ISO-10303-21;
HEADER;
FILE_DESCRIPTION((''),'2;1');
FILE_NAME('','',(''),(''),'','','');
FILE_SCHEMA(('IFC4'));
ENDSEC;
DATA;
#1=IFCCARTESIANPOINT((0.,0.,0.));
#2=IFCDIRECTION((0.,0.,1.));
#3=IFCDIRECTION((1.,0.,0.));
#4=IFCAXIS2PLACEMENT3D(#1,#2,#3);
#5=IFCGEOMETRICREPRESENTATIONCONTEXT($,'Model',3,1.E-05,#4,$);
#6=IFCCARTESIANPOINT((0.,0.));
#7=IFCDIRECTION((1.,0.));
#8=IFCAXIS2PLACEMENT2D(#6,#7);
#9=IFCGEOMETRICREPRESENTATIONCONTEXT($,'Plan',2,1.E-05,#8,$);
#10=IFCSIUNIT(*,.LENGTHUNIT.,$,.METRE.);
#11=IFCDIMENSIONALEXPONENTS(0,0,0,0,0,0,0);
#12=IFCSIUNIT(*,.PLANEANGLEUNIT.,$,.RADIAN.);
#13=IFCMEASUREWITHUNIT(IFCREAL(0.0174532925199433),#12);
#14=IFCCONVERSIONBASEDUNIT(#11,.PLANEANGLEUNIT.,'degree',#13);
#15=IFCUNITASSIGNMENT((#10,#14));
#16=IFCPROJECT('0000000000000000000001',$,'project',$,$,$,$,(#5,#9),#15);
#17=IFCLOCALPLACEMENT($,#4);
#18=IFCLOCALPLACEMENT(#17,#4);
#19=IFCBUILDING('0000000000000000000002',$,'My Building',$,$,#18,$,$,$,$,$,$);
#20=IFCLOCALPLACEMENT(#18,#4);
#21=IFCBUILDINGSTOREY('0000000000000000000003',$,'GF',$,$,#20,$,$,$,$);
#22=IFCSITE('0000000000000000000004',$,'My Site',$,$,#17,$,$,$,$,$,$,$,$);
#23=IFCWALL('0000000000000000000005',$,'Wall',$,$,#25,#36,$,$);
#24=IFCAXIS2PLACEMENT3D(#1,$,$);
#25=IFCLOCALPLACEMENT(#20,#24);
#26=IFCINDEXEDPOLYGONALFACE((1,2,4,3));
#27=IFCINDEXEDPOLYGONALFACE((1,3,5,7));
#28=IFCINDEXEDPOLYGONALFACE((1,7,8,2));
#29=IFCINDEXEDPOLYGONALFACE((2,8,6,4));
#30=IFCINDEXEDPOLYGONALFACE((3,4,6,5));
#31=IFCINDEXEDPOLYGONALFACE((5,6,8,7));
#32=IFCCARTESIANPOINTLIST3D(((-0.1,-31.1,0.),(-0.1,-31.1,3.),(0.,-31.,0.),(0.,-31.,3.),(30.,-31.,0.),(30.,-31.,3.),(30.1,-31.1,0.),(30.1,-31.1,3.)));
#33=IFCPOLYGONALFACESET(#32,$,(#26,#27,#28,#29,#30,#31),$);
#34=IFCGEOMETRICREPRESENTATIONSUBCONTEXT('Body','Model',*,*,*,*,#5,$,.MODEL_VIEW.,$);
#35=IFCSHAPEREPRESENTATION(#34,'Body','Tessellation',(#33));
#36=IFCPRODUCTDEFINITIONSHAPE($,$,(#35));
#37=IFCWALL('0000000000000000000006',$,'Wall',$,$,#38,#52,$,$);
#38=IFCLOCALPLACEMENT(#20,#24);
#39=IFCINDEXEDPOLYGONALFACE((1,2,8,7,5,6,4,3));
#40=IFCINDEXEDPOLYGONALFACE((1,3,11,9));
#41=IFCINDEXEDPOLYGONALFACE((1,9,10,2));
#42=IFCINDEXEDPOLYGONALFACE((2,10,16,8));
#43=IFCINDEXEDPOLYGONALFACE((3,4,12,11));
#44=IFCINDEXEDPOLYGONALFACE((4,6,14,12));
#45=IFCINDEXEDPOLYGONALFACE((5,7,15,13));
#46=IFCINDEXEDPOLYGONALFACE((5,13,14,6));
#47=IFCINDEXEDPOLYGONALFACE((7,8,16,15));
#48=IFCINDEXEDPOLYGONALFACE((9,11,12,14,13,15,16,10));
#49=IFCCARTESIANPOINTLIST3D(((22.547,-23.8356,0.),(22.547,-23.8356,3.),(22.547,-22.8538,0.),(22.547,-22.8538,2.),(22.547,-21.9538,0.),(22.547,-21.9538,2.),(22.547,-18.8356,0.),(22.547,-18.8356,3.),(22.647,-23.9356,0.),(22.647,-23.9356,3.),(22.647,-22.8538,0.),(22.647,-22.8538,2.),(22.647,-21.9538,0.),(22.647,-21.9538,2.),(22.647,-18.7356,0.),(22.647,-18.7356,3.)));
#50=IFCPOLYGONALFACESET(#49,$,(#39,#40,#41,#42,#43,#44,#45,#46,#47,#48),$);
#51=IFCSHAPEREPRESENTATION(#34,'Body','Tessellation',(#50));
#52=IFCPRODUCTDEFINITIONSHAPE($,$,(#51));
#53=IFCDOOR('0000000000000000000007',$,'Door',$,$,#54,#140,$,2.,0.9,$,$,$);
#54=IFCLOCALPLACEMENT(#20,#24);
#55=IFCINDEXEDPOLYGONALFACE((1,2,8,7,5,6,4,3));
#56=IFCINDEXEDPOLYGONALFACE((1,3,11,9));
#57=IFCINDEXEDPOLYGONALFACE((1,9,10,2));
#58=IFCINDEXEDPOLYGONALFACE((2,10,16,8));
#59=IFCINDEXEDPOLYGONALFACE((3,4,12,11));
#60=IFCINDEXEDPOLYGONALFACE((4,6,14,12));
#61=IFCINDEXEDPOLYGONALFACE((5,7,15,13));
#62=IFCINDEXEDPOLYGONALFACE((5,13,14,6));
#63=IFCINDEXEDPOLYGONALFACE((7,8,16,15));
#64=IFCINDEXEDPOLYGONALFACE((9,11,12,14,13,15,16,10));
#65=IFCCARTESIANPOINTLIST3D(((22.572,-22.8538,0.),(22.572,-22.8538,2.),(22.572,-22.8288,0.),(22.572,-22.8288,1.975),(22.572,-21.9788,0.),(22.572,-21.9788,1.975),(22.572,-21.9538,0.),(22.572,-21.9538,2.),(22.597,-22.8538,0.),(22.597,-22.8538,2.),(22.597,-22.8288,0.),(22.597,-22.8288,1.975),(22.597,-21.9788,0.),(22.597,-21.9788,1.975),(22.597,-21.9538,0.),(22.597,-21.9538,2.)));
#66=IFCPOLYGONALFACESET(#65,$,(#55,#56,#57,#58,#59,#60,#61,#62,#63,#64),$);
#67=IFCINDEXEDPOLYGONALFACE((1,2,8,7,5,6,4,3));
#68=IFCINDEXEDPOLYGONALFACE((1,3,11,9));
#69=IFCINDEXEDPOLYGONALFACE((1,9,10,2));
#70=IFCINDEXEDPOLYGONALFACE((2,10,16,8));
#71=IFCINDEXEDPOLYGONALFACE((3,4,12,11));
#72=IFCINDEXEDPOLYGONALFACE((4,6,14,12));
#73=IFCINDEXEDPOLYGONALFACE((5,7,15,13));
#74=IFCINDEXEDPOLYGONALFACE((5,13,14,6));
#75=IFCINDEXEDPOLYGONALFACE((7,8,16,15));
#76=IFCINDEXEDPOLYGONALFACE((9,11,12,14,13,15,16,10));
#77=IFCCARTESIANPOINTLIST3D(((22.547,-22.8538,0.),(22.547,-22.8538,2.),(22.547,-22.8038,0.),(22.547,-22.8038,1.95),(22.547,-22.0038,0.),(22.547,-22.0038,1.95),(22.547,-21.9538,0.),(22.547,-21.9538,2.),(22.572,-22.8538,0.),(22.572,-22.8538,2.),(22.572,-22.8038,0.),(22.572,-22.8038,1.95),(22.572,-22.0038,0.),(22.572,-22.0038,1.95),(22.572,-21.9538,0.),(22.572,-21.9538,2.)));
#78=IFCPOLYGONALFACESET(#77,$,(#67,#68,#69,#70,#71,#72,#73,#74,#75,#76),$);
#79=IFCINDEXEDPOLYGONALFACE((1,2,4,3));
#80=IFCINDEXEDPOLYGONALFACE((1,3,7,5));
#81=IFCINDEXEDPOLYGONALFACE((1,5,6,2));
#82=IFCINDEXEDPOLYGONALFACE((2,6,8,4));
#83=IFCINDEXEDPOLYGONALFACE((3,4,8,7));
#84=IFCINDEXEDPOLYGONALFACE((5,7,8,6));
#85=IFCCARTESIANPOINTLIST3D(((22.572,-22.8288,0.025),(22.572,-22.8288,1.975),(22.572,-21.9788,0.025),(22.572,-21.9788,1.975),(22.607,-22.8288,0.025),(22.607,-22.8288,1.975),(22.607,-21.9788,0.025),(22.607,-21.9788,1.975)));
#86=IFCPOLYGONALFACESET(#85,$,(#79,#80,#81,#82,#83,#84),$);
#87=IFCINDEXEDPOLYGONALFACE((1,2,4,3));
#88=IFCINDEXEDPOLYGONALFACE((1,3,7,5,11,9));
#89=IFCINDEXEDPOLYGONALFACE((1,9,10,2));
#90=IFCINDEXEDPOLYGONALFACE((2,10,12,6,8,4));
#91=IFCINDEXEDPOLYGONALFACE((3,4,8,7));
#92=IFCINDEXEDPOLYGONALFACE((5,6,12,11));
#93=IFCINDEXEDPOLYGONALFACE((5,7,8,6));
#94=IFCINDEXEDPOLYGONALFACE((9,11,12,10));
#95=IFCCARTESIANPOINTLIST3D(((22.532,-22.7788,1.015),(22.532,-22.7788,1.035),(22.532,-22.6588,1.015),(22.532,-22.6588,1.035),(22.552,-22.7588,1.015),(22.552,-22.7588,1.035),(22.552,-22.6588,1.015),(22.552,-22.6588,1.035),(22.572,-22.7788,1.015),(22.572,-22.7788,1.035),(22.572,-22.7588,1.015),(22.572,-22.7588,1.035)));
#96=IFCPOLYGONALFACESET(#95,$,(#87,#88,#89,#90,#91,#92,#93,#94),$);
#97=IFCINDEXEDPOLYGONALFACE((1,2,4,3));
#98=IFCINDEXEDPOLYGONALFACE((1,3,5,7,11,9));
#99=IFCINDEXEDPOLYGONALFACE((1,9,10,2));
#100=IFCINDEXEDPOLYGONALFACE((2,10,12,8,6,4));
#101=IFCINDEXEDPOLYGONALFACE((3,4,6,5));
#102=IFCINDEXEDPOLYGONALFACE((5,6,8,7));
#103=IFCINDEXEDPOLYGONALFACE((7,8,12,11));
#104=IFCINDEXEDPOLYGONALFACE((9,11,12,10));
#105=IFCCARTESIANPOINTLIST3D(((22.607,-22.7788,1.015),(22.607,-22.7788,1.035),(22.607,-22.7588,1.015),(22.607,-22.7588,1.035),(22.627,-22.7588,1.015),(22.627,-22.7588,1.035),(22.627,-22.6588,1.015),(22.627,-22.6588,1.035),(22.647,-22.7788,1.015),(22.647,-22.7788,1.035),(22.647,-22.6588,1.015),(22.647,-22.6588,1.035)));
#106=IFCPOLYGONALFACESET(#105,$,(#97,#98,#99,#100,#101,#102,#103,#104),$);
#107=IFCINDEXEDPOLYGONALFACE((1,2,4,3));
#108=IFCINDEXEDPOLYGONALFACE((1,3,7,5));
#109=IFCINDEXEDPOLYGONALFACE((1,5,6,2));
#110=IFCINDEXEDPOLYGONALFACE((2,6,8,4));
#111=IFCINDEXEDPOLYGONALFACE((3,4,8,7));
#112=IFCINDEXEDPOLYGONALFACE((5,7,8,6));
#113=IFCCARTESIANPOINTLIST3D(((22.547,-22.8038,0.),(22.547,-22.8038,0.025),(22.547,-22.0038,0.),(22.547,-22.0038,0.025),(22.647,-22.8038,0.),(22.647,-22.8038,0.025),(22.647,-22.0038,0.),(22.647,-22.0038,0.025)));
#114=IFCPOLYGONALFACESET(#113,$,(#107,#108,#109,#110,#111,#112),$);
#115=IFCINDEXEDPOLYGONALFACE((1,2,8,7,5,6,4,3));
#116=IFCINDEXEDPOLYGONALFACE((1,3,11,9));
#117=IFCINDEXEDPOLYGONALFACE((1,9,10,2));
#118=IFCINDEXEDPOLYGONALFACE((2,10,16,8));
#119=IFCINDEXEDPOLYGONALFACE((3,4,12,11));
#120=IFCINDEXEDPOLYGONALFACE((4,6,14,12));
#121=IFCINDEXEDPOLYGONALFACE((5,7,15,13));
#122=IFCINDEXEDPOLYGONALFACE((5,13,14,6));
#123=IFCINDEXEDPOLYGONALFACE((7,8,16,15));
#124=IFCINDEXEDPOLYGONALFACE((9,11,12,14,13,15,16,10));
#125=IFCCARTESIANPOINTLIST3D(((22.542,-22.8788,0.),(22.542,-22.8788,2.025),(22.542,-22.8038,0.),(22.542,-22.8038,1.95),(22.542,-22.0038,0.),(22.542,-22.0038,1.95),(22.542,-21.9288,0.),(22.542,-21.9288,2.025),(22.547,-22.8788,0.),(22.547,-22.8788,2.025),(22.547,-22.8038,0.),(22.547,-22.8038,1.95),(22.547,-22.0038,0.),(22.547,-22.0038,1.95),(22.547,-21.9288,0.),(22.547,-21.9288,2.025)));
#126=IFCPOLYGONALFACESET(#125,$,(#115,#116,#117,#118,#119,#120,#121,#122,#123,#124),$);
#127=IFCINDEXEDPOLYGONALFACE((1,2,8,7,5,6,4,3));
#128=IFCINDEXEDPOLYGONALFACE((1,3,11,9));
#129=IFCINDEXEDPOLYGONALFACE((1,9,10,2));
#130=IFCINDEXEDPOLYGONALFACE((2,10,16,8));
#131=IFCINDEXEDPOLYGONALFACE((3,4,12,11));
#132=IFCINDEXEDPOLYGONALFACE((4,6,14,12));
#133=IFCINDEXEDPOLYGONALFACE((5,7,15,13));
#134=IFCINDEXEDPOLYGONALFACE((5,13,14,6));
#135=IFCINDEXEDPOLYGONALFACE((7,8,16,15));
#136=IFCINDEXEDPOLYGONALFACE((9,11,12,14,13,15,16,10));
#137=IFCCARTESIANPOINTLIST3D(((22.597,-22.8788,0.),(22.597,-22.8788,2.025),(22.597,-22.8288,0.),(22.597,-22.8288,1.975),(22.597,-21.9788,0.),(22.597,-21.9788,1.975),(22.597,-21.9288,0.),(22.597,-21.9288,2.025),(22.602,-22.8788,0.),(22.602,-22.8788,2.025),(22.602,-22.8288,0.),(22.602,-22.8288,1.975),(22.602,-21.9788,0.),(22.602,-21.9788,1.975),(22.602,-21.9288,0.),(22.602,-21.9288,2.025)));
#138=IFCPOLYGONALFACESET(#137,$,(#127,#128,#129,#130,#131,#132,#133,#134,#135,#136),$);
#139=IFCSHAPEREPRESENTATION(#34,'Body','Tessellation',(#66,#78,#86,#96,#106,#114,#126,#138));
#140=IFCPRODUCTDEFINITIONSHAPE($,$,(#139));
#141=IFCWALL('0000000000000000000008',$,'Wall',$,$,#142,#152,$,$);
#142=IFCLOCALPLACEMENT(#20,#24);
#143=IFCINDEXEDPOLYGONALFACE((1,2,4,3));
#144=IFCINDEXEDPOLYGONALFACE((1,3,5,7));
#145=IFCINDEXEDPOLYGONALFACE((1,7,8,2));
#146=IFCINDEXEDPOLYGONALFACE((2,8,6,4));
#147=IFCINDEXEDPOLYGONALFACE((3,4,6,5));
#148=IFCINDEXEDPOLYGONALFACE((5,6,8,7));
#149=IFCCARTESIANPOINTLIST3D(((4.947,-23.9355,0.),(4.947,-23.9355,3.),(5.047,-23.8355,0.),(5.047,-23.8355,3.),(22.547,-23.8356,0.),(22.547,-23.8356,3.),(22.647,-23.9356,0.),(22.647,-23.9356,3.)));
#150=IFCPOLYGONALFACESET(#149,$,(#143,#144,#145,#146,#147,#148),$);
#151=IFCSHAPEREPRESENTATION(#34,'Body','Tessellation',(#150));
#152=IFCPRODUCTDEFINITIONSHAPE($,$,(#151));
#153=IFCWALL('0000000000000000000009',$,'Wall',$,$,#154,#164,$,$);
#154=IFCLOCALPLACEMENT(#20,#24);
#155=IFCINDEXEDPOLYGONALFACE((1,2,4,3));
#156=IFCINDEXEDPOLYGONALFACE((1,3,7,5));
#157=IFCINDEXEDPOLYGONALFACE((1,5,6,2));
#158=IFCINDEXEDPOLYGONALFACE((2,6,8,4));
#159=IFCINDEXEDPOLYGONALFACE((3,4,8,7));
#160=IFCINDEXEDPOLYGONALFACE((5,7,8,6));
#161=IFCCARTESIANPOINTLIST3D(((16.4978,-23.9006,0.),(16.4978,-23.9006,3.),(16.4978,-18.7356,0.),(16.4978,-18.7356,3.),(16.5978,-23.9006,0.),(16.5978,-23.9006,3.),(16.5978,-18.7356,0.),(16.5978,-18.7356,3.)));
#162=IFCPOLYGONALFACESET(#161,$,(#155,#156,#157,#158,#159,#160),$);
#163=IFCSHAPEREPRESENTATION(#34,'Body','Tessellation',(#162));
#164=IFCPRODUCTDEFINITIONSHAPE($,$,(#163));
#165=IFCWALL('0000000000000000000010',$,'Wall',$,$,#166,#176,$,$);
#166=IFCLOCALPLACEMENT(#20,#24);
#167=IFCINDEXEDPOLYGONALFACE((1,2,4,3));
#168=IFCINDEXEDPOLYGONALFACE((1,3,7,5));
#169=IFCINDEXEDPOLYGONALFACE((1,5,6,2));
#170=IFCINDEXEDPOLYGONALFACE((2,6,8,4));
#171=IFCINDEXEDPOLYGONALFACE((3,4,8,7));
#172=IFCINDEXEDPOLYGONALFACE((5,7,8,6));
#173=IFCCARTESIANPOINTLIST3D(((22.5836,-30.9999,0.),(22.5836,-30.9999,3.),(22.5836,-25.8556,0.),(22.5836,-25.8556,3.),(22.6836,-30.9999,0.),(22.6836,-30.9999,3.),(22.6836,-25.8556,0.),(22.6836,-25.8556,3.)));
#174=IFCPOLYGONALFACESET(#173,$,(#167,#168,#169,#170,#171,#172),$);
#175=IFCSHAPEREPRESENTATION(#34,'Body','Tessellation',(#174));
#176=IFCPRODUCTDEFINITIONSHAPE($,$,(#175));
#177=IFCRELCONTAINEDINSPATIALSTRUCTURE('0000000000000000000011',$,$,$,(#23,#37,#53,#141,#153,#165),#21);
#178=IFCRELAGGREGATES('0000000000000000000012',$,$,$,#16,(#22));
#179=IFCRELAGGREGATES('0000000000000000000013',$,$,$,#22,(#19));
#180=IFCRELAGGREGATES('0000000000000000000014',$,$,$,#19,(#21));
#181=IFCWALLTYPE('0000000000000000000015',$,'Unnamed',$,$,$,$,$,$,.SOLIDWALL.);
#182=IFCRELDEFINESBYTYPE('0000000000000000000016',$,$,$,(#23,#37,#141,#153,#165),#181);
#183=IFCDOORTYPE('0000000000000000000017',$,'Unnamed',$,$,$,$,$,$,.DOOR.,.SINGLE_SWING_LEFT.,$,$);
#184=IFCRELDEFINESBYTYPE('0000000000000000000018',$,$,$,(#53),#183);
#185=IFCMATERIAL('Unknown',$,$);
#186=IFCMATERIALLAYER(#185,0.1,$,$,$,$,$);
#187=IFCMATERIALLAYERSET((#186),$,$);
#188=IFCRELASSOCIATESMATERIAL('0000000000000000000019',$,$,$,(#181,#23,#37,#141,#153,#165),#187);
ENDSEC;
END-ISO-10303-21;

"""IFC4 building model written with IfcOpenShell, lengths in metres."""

from ifc_helpers import new_model, entity, si_unit, converted_unit, frame, origin_with_axes, origin_2d_with_axis, place, context, subcontext, project, spatial, line, indexed_curve, outline, extrude, shape, source, transform, mapped, material, layer, layer_set, layer_usage, type_object, type_shapes, element, fill, save


model = new_model("IFC4")

# Units and contexts
model_context = context("Model", 3, precision=1e-05, world=origin_with_axes())
plan_context = context("Plan", 2, precision=1e-05, world=origin_2d_with_axis())
body_context_1 = subcontext(model_context, "Body", "Model", "MODEL_VIEW")
body_context_2 = subcontext(plan_context, "Body", "Plan", "PLAN_VIEW")
ifc_project = project(units=[si_unit("LENGTHUNIT", "METRE"), converted_unit("PLANEANGLEUNIT", "degree", entity("IfcReal", 0.0174532925199433), si_unit("PLANEANGLEUNIT", "RADIAN"), dimensions=[0, 0, 0, 0, 0, 0, 0])], contexts=[model_context, plan_context])

# Site, building, storey
site_placement = place(None, origin_with_axes())
site = spatial("IfcSite", under=ifc_project, at=site_placement, Name="My Site")
building_placement = place(site_placement, origin_with_axes())
building = spatial("IfcBuilding", under=site, at=building_placement, Name="My Building")
storey_placement = place(building_placement, origin_with_axes())
storey = spatial("IfcBuildingStorey", under=building, at=storey_placement, Name="GF")

# Wall
ifc_material = material(Name="Unknown")
ifc_layer = layer(ifc_material, 0.1)
ifc_layer_set = layer_set([ifc_layer])
ifc_layer_usage_1 = layer_usage(ifc_layer_set, "AXIS2", "POSITIVE", 0.0)
wall_type = type_object("IfcWallType", Name="Unnamed", PredefinedType="SOLIDWALL", material=ifc_layer_set)
wall_1_placement = place(storey_placement, frame((30.0, -31.0, 0.0), z_axis=(0.0, 0.0, 1.0), x_axis=(-1.0, 0.0, 0.0)))
element("IfcWall", 1, at=wall_1_placement, inside=storey, type_object=wall_type, material=ifc_layer_usage_1, Name="Wall", context=body_context_1, shape_type="SweptSolid", body=[
    extrude(outline(indexed_curve([(0.0, 0.0), (-0.1, 0.1), (30.1, 0.1), (30.0, 0.0)], segments=[line(1, 2, 3, 4, 1)])), origin_with_axes(), (0.0, 0.0, 1.0), 3.0),
])

# Wall, opening, door
ifc_layer_usage_2 = layer_usage(ifc_layer_set, "AXIS2", "POSITIVE", 0.0)
wall_2_placement = place(storey_placement, frame((22.547, -18.8356, 0.0), z_axis=(0.0, 0.0, 1.0), x_axis=(0.0, -1.0, 0.0)))
wall_2 = element("IfcWall", 2, at=wall_2_placement, inside=storey, type_object=wall_type, material=ifc_layer_usage_2, Name="Wall", context=body_context_1, shape_type="SweptSolid", body=[
    extrude(outline(indexed_curve([(0.0, 0.0), (-0.1, 0.1), (5.1, 0.1), (5.0, 0.0)], segments=[line(1, 2, 3, 4, 1)])), origin_with_axes(), (0.0, 0.0, 1.0), 3.0),
])
shared_shape_1 = source(origin_with_axes(), body_context_1, "Body", "SweptSolid", [
    extrude(outline(indexed_curve([(0.0, 0.0), (0.9, 0.0), (0.9, 2.0), (0.0, 2.0)], segments=[line(1, 2, 3, 4, 1)])), frame((0.0, -0.6, 0.0), z_axis=(0.0, -1.0, 0.0), x_axis=(1.0, 0.0, 0.0)), (0.0, 0.0, -1.0), 1.2),
])
opening_placement = place(wall_2_placement, frame((3.1182, 0.0, 0.0), z_axis=(0.0, 0.0, 1.0), x_axis=(1.0, 0.0, 0.0)))
opening = element("IfcOpeningElement", 3, at=opening_placement, cuts=wall_2, PredefinedType="OPENING", context=body_context_1, shape_type="MappedRepresentation", body=[
    mapped(shared_shape_1, transform((0.0, 0.0, 0.0), x_axis=(1.0, 0.0, 0.0), y_axis=(0.0, 1.0, 0.0), z_axis=(0.0, 0.0, 1.0), scale=1.0)),
])
door_type = type_object("IfcDoorType", Name="Unnamed", OperationType="SINGLE_SWING_LEFT", PredefinedType="DOOR")
shared_shape_2 = source(origin_with_axes(), body_context_1, "Body", "SweptSolid", [
    extrude(outline(indexed_curve([(0.0, 0.0), (0.0, 2.0), (0.9, 2.0), (0.9, 0.0), (0.875, 0.0), (0.875, 1.975), (0.025, 1.975), (0.025, 0.0)], segments=[line(1, 2, 3, 4, 5, 6, 7, 8, 1)])), frame((0.0, 0.025, 0.0), z_axis=(0.0, -1.0, 0.0), x_axis=(1.0, 0.0, 0.0)), (0.0, 0.0, -1.0), 0.025),
    extrude(outline(indexed_curve([(0.0, 0.0), (0.0, 2.0), (0.9, 2.0), (0.9, 0.0), (0.85, 0.0), (0.85, 1.95), (0.05, 1.95), (0.05, 0.0)], segments=[line(1, 2, 3, 4, 5, 6, 7, 8, 1)])), frame((0.0, 0.0, 0.0), z_axis=(0.0, -1.0, 0.0), x_axis=(1.0, 0.0, 0.0)), (0.0, 0.0, -1.0), 0.025),
    extrude(outline(indexed_curve([(0.0, 0.0), (0.85, 0.0), (0.85, 0.035), (0.0, 0.035)], segments=[line(1, 2, 3, 4, 1)])), frame((0.025, 0.025, 0.025), z_axis=(0.0, 0.0, 1.0), x_axis=(1.0, 0.0, 0.0)), (0.0, 0.0, 1.0), 1.95),
    extrude(outline(indexed_curve([(0.0, 0.0), (0.0, -0.04), (-0.12, -0.04), (-0.12, -0.02), (-0.02, -0.02), (-0.02, 0.0)], segments=[line(1, 2, 3, 4, 5, 6, 1)])), frame((0.825, 0.025, 1.015), z_axis=(0.0, 0.0, 1.0), x_axis=(1.0, 0.0, 0.0)), (0.0, 0.0, 1.0), 0.02),
    extrude(outline(indexed_curve([(0.0, 0.0), (0.0, 0.04), (-0.12, 0.04), (-0.12, 0.02), (-0.02, 0.02), (-0.02, 0.0)], segments=[line(1, 2, 3, 4, 5, 6, 1)])), frame((0.825, 0.06, 1.015), z_axis=(0.0, 0.0, 1.0), x_axis=(1.0, 0.0, 0.0)), (0.0, 0.0, 1.0), 0.02),
    extrude(outline(indexed_curve([(0.0, 0.0), (0.8, 0.0), (0.8, 0.1), (0.0, 0.1)], segments=[line(1, 2, 3, 4, 1)])), frame((0.05, 0.0, 0.0), z_axis=(0.0, 0.0, 1.0), x_axis=(1.0, 0.0, 0.0)), (0.0, 0.0, 1.0), 0.025),
    extrude(outline(indexed_curve([(0.0, 0.0), (0.0, 2.025), (0.95, 2.025), (0.95, 0.0), (0.875, 0.0), (0.875, 1.95), (0.075, 1.95), (0.075, 0.0)], segments=[line(1, 2, 3, 4, 5, 6, 7, 8, 1)])), frame((-0.025, -0.005, 0.0), z_axis=(0.0, -1.0, 0.0), x_axis=(1.0, 0.0, 0.0)), (0.0, 0.0, -1.0), 0.005),
    extrude(outline(indexed_curve([(0.0, 0.0), (0.0, 2.025), (0.95, 2.025), (0.95, 0.0), (0.9, 0.0), (0.9, 1.975), (0.05, 1.975), (0.05, 0.0)], segments=[line(1, 2, 3, 4, 5, 6, 7, 8, 1)])), frame((-0.025, 0.05, 0.0), z_axis=(0.0, -1.0, 0.0), x_axis=(1.0, 0.0, 0.0)), (0.0, 0.0, -1.0), 0.005),
])
shared_shape_3 = source(origin_with_axes(), body_context_2, "Body", "Curve2D", [
    entity("IfcIndexedPolyCurve", entity("IfcCartesianPointList2D", [[0.0, 0.0], [0.0, 0.05], [0.025, 0.05], [0.025, 0.025], [0.05, 0.025], [0.05, 0.0]]), [entity("IfcLineIndex", [1, 2, 3, 4, 5, 6, 1])]),
    entity("IfcIndexedPolyCurve", entity("IfcCartesianPointList2D", [[0.9, 0.0], [0.9, 0.05], [0.875, 0.05], [0.875, 0.025], [0.85, 0.025], [0.85, 0.0]]), [entity("IfcLineIndex", [1, 2, 3, 4, 5, 6, 1])]),
    entity("IfcTrimmedCurve", entity("IfcEllipse", entity("IfcAxis2Placement2D", entity("IfcCartesianPoint", [0.06, 0.05]), entity("IfcDirection", [1.0, 0.0])), 0.815, 0.85), [entity("IfcCartesianPoint", [0.875, 0.05])], [entity("IfcCartesianPoint", [0.06, 0.9])], True, "CARTESIAN"),
    entity("IfcIndexedPolyCurve", entity("IfcCartesianPointList2D", [[0.025, 0.05], [0.06, 0.05], [0.06, 0.9], [0.025, 0.9]]), [entity("IfcLineIndex", [1, 2, 3, 4, 1])]),
])
type_shapes(door_type, [shared_shape_2, shared_shape_3])
door_placement = place(opening_placement, frame((0.0, 0.0, 0.0), z_axis=(0.0, 0.0, 1.0), x_axis=(1.0, 0.0, 0.0)))
door = element("IfcDoor", 4, at=door_placement, inside=storey, type_object=door_type, Name="Door", OverallHeight=2.0, OverallWidth=0.9, shapes=[
    shape(body_context_1, "Body", "MappedRepresentation", [mapped(shared_shape_2, transform((0.0, 0.0, 0.0), x_axis=(1.0, 0.0, 0.0), y_axis=(0.0, 1.0, 0.0), z_axis=(0.0, 0.0, 1.0), scale=1.0))]),
    shape(body_context_2, "Body", "MappedRepresentation", [mapped(shared_shape_3, transform((0.0, 0.0, 0.0), x_axis=(1.0, 0.0, 0.0), y_axis=(0.0, 1.0, 0.0), z_axis=(0.0, 0.0, 1.0), scale=1.0))]),
])
fill(opening, door)

# Walls
ifc_layer_usage_3 = layer_usage(ifc_layer_set, "AXIS2", "POSITIVE", 0.0)
wall_3_placement = place(storey_placement, frame((22.547, -23.8356, 0.0), z_axis=(0.0, 0.0, 1.0), x_axis=(-1.0, 0.0, 0.0)))
element("IfcWall", 5, at=wall_3_placement, inside=storey, type_object=wall_type, material=ifc_layer_usage_3, Name="Wall", context=body_context_1, shape_type="SweptSolid", body=[
    extrude(outline(indexed_curve([(0.0, 0.0), (-0.1, 0.1), (17.6, 0.1), (17.5, 0.0)], segments=[line(1, 2, 3, 4, 1)])), origin_with_axes(), (0.0, 0.0, 1.0), 3.0),
])
ifc_layer_usage_4 = layer_usage(ifc_layer_set, "AXIS2", "POSITIVE", 0.0)
wall_4_placement = place(storey_placement, frame((16.4978, -18.7356, 0.0), z_axis=(0.0, 0.0, 1.0), x_axis=(0.0, -1.0, 0.0)))
element("IfcWall", 6, at=wall_4_placement, inside=storey, type_object=wall_type, material=ifc_layer_usage_4, Name="Wall", context=body_context_1, shape_type="SweptSolid", body=[
    extrude(outline(indexed_curve([(0.0, 0.0), (0.0, 0.1), (5.1651, 0.1), (5.1651, 0.0)], segments=[line(1, 2, 3, 4, 1)])), origin_with_axes(), (0.0, 0.0, 1.0), 3.0),
])
ifc_layer_usage_5 = layer_usage(ifc_layer_set, "AXIS2", "POSITIVE", 0.0)
wall_5_placement = place(storey_placement, frame((22.5836, -25.8556, 0.0), z_axis=(0.0, 0.0, 1.0), x_axis=(0.0, -1.0, 0.0)))
element("IfcWall", 7, at=wall_5_placement, inside=storey, type_object=wall_type, material=ifc_layer_usage_5, Name="Wall", context=body_context_1, shape_type="SweptSolid", body=[
    extrude(outline(indexed_curve([(0.0, 0.0), (0.0, 0.1), (5.1443, 0.1), (5.1443, 0.0)], segments=[line(1, 2, 3, 4, 1)])), origin_with_axes(), (0.0, 0.0, 1.0), 3.0),
])

save(model, "model.ifc")
